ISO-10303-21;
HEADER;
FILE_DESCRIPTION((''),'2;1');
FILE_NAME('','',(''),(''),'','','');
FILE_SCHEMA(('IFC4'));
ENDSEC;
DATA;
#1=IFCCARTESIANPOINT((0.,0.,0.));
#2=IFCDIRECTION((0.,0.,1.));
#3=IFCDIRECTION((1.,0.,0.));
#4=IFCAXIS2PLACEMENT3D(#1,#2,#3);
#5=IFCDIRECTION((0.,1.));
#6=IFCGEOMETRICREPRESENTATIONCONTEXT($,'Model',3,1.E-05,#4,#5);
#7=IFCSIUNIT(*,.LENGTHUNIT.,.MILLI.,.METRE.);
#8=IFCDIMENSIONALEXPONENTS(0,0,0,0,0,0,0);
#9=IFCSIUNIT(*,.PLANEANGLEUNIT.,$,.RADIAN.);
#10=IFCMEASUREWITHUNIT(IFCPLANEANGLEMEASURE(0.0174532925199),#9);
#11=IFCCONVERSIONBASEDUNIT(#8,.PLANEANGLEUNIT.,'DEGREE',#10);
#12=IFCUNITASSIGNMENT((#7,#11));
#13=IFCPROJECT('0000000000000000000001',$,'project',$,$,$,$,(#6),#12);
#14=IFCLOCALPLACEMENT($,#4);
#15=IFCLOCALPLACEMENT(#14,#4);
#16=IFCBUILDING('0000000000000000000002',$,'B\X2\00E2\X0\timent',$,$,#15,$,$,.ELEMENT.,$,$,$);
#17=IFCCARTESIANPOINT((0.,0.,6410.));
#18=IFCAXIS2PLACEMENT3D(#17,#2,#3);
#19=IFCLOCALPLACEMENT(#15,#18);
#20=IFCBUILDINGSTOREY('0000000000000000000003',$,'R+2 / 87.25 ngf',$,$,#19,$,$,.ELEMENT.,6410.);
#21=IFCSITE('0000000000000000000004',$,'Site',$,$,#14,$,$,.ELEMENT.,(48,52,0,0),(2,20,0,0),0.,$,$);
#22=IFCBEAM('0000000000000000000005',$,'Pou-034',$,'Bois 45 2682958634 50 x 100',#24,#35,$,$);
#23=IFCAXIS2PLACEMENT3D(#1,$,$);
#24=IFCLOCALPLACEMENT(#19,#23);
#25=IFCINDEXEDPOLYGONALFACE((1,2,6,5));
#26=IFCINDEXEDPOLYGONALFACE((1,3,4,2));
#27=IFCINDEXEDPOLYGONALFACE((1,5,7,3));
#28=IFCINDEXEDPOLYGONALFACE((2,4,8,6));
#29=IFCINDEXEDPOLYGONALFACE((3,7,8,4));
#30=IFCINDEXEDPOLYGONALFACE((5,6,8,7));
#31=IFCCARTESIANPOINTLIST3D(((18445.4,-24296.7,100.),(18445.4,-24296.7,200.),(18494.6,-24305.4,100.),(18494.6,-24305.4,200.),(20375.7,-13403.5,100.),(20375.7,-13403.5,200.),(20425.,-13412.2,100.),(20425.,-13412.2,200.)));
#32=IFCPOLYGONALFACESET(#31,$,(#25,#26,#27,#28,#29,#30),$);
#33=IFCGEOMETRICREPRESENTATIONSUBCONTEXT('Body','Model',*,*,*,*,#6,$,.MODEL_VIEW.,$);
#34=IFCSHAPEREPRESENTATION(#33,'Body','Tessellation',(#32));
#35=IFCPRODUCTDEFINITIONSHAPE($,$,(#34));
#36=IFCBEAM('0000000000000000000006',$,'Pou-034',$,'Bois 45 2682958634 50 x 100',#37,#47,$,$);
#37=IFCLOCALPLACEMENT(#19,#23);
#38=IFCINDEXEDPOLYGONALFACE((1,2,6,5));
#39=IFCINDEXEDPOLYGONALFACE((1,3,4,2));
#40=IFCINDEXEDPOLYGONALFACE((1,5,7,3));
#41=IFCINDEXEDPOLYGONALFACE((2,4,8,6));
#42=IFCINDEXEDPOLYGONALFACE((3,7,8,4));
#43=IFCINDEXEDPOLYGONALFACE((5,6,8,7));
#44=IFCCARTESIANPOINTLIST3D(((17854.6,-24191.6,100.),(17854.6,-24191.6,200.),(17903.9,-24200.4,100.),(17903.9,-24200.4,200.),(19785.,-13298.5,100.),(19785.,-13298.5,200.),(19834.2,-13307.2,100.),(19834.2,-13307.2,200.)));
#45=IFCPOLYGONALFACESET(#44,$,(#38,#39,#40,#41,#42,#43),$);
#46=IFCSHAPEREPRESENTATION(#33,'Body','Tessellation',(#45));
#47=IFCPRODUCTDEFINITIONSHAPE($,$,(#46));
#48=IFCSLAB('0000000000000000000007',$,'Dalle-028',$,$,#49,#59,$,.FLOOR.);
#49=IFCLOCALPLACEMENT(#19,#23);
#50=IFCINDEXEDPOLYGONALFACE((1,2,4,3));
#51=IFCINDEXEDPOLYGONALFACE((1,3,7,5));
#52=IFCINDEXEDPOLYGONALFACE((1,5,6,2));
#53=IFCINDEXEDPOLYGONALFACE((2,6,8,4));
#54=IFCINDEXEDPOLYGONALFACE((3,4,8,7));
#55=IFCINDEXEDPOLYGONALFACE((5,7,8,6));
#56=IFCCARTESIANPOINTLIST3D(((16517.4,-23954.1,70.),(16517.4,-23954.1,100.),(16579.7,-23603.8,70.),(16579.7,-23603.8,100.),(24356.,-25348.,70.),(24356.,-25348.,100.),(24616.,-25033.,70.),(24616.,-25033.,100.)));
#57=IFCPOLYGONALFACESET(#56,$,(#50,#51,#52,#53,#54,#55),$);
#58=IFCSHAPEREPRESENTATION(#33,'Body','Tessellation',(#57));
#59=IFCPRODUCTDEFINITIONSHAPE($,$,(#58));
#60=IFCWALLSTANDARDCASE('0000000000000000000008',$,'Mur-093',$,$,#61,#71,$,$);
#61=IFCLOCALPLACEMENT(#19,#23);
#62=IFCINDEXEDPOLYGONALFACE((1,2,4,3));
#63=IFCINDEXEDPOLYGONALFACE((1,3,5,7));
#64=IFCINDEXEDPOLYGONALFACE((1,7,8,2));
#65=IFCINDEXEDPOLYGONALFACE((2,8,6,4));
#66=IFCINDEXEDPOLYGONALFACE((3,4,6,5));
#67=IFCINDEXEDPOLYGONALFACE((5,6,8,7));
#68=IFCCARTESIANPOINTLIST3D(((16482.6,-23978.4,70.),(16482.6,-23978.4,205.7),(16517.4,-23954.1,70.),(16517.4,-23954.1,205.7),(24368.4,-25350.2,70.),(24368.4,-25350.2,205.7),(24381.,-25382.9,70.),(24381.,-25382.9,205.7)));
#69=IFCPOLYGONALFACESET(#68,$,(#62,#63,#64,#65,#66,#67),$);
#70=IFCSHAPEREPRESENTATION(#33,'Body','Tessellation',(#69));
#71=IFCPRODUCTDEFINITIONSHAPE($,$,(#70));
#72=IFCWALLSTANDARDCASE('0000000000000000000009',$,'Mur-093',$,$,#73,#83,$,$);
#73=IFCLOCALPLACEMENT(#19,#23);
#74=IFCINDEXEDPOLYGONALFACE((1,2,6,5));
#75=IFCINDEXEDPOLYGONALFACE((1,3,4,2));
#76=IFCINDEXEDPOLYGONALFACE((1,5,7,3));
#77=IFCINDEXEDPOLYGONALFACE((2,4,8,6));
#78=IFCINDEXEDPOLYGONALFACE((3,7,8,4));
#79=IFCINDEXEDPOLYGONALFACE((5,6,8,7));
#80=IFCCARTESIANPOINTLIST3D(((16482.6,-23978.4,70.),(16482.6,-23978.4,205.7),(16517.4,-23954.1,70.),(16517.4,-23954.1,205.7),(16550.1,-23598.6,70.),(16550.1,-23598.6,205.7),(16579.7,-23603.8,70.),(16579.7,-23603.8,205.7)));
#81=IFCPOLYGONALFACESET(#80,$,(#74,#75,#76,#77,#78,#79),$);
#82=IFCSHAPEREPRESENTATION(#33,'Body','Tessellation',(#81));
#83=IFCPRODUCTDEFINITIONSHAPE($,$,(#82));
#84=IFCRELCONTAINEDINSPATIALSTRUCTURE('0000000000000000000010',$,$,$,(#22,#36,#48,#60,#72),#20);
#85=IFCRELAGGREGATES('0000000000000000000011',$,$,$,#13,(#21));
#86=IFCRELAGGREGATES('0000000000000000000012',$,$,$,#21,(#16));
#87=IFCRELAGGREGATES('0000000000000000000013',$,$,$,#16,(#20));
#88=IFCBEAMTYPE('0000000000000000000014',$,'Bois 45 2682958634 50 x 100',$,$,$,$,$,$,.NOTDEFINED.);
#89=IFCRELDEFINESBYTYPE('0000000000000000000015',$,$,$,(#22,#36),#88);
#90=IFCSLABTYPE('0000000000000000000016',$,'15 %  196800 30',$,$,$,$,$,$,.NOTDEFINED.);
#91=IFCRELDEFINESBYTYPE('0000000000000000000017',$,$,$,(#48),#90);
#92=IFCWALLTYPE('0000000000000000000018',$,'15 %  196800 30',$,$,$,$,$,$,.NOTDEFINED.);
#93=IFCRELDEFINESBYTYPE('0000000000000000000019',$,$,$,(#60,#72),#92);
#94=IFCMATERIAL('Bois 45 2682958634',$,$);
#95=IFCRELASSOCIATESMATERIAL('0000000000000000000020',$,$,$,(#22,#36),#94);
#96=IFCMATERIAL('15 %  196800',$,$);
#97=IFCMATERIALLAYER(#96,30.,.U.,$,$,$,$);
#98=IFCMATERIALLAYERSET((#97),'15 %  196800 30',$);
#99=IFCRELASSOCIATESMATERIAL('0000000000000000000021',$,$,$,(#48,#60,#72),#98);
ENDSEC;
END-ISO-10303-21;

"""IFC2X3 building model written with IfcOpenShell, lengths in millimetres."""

from ifc_helpers import new_model, entity, si_unit, converted_unit, direction, frame, frame_2d, origin_with_axes, place, context, subcontext, project, spatial, polyline, rectangle, outline, extrude, material, layer, layer_set, layer_usage, type_object, element, save


model = new_model("IFC2X3")

# Units and contexts
model_context = context("Model", 3, precision=1e-05, world=origin_with_axes(), true_north=direction((0.0, 1.0)))
body_context = subcontext(model_context, "Body", "Model", "MODEL_VIEW")
ifc_project = project(units=[si_unit("LENGTHUNIT", "METRE", prefix="MILLI"), converted_unit("PLANEANGLEUNIT", "DEGREE", entity("IfcPlaneAngleMeasure", 0.0174532925199), si_unit("PLANEANGLEUNIT", "RADIAN"), dimensions=[0, 0, 0, 0, 0, 0, 0])], contexts=[model_context])

# Site, building, storey
site_placement = place(None, origin_with_axes())
site = spatial("IfcSite", under=ifc_project, at=site_placement, Name="Site", CompositionType="ELEMENT", RefLatitude=(48, 52, 0, 0), RefLongitude=(2, 20, 0, 0), RefElevation=0.0)
building_placement = place(site_placement, origin_with_axes())
building = spatial("IfcBuilding", under=site, at=building_placement, Name="Bâtiment", CompositionType="ELEMENT")
storey_placement = place(building_placement, frame((0.0, 0.0, 6410.0), z_axis=(0.0, 0.0, 1.0), x_axis=(1.0, 0.0, 0.0)))
storey = spatial("IfcBuildingStorey", under=building, at=storey_placement, Name="R+2 / 87.25 ngf", CompositionType="ELEMENT", Elevation=6410.0)

# Beams
ifc_material_1 = material(Name="Bois 45 2682958634")
beam_type = type_object("IfcBeamType", Name="Bois 45 2682958634 50 x 100", PredefinedType="NOTDEFINED")
for number, where, z_axis, x_axis, name in (
    (1, (18470.0, -24301.0, 200.0), (0.0, 0.0, 1.0), (0.984659, -0.174492, 0.0), "Pou-034"),
    (2, (17879.2, -24196.0, 200.0), (0.0, 0.0, 1.0), (0.984659, -0.174492, 0.0), "Pou-034"),
):
    element("IfcBeam", number, at=place(storey_placement, frame(where, z_axis=z_axis, x_axis=x_axis)), inside=storey, type_object=beam_type, material=ifc_material_1, Name=name, ObjectType="Bois 45 2682958634 50 x 100", context=body_context, shape_type="SweptSolid", body=[
        extrude(rectangle(XDim=100.0, YDim=50.0, at=frame_2d((-50.0, 0.0), x_axis=(1.0, 0.0))), frame((0.0, 0.0, 0.0), z_axis=(0.0, 1.0, 0.0), x_axis=(0.0, 0.0, 1.0)), (0.0, 0.0, 1.0), 11062.9),
    ])

# Slab
ifc_material_2 = material(Name="15 %  196800")
ifc_layer_1 = layer(ifc_material_2, 30.0, ventilated="UNKNOWN")
ifc_layer_set_1 = layer_set([ifc_layer_1], Name="15 %  196800 30")
ifc_layer_usage_1 = layer_usage(ifc_layer_set_1, "AXIS3", "NEGATIVE", 30.0)
slab_type_1 = type_object("IfcSlabType", Name="15 %  196800 30", PredefinedType="NOTDEFINED")
slab_1_placement = place(storey_placement, frame((16517.4, -23954.1, 100.0), z_axis=(0.0, 0.0, 1.0), x_axis=(1.0, 0.0, 0.0)))
element("IfcSlab", 3, at=slab_1_placement, inside=storey, type_object=slab_type_1, material=ifc_layer_usage_1, Name="Dalle-028", PredefinedType="FLOOR", context=body_context, shape_type="SweptSolid", body=[
    extrude(outline(polyline([(0.0, 0.0), (7838.6, -1393.8), (8098.7, -1078.9), (62.3, 350.3), (0.0, 0.0)])), frame((0.0, 0.0, -30.0), z_axis=(0.0, 0.0, 1.0), x_axis=(1.0, 0.0, 0.0)), (0.0, 0.0, 1.0), 30.0),
])

# Walls
ifc_layer_usage_2 = layer_usage(ifc_layer_set_1, "AXIS2", "POSITIVE", -30.0)
wall_type = type_object("IfcWallType", Name="15 %  196800 30", PredefinedType="NOTDEFINED")
wall_1_placement = place(storey_placement, frame((16517.4, -23954.1, 70.0), z_axis=(0.0, 0.0, 1.0), x_axis=(0.984556, -0.17507, 0.0)))
element("IfcWallStandardCase", 4, at=wall_1_placement, inside=storey, type_object=wall_type, material=ifc_layer_usage_2, Name="Mur-093", context=body_context, shape_type="SweptSolid", body=[
    extrude(outline(polyline([(-30.0, -30.0), (7992.3, -30.0), (7974.2, 0.0), (0.0, 0.0), (-30.0, -30.0)])), origin_with_axes(), (0.0, 0.0, 1.0), 135.7),
])
ifc_layer_usage_3 = layer_usage(ifc_layer_set_1, "AXIS2", "NEGATIVE", 30.0)
wall_2_placement = place(storey_placement, frame((16517.4, -23954.1, 70.0), z_axis=(0.0, 0.0, 1.0), x_axis=(0.175099, 0.984551, 0.0)))
element("IfcWallStandardCase", 5, at=wall_2_placement, inside=storey, type_object=wall_type, material=ifc_layer_usage_3, Name="Mur-093", context=body_context, shape_type="SweptSolid", body=[
    extrude(outline(polyline([(0.0, 0.0), (355.8, 0.0), (355.8, 30.0), (-30.0, 30.0), (0.0, 0.0)])), origin_with_axes(), (0.0, 0.0, 1.0), 135.7),
])

save(model, "model.ifc")
